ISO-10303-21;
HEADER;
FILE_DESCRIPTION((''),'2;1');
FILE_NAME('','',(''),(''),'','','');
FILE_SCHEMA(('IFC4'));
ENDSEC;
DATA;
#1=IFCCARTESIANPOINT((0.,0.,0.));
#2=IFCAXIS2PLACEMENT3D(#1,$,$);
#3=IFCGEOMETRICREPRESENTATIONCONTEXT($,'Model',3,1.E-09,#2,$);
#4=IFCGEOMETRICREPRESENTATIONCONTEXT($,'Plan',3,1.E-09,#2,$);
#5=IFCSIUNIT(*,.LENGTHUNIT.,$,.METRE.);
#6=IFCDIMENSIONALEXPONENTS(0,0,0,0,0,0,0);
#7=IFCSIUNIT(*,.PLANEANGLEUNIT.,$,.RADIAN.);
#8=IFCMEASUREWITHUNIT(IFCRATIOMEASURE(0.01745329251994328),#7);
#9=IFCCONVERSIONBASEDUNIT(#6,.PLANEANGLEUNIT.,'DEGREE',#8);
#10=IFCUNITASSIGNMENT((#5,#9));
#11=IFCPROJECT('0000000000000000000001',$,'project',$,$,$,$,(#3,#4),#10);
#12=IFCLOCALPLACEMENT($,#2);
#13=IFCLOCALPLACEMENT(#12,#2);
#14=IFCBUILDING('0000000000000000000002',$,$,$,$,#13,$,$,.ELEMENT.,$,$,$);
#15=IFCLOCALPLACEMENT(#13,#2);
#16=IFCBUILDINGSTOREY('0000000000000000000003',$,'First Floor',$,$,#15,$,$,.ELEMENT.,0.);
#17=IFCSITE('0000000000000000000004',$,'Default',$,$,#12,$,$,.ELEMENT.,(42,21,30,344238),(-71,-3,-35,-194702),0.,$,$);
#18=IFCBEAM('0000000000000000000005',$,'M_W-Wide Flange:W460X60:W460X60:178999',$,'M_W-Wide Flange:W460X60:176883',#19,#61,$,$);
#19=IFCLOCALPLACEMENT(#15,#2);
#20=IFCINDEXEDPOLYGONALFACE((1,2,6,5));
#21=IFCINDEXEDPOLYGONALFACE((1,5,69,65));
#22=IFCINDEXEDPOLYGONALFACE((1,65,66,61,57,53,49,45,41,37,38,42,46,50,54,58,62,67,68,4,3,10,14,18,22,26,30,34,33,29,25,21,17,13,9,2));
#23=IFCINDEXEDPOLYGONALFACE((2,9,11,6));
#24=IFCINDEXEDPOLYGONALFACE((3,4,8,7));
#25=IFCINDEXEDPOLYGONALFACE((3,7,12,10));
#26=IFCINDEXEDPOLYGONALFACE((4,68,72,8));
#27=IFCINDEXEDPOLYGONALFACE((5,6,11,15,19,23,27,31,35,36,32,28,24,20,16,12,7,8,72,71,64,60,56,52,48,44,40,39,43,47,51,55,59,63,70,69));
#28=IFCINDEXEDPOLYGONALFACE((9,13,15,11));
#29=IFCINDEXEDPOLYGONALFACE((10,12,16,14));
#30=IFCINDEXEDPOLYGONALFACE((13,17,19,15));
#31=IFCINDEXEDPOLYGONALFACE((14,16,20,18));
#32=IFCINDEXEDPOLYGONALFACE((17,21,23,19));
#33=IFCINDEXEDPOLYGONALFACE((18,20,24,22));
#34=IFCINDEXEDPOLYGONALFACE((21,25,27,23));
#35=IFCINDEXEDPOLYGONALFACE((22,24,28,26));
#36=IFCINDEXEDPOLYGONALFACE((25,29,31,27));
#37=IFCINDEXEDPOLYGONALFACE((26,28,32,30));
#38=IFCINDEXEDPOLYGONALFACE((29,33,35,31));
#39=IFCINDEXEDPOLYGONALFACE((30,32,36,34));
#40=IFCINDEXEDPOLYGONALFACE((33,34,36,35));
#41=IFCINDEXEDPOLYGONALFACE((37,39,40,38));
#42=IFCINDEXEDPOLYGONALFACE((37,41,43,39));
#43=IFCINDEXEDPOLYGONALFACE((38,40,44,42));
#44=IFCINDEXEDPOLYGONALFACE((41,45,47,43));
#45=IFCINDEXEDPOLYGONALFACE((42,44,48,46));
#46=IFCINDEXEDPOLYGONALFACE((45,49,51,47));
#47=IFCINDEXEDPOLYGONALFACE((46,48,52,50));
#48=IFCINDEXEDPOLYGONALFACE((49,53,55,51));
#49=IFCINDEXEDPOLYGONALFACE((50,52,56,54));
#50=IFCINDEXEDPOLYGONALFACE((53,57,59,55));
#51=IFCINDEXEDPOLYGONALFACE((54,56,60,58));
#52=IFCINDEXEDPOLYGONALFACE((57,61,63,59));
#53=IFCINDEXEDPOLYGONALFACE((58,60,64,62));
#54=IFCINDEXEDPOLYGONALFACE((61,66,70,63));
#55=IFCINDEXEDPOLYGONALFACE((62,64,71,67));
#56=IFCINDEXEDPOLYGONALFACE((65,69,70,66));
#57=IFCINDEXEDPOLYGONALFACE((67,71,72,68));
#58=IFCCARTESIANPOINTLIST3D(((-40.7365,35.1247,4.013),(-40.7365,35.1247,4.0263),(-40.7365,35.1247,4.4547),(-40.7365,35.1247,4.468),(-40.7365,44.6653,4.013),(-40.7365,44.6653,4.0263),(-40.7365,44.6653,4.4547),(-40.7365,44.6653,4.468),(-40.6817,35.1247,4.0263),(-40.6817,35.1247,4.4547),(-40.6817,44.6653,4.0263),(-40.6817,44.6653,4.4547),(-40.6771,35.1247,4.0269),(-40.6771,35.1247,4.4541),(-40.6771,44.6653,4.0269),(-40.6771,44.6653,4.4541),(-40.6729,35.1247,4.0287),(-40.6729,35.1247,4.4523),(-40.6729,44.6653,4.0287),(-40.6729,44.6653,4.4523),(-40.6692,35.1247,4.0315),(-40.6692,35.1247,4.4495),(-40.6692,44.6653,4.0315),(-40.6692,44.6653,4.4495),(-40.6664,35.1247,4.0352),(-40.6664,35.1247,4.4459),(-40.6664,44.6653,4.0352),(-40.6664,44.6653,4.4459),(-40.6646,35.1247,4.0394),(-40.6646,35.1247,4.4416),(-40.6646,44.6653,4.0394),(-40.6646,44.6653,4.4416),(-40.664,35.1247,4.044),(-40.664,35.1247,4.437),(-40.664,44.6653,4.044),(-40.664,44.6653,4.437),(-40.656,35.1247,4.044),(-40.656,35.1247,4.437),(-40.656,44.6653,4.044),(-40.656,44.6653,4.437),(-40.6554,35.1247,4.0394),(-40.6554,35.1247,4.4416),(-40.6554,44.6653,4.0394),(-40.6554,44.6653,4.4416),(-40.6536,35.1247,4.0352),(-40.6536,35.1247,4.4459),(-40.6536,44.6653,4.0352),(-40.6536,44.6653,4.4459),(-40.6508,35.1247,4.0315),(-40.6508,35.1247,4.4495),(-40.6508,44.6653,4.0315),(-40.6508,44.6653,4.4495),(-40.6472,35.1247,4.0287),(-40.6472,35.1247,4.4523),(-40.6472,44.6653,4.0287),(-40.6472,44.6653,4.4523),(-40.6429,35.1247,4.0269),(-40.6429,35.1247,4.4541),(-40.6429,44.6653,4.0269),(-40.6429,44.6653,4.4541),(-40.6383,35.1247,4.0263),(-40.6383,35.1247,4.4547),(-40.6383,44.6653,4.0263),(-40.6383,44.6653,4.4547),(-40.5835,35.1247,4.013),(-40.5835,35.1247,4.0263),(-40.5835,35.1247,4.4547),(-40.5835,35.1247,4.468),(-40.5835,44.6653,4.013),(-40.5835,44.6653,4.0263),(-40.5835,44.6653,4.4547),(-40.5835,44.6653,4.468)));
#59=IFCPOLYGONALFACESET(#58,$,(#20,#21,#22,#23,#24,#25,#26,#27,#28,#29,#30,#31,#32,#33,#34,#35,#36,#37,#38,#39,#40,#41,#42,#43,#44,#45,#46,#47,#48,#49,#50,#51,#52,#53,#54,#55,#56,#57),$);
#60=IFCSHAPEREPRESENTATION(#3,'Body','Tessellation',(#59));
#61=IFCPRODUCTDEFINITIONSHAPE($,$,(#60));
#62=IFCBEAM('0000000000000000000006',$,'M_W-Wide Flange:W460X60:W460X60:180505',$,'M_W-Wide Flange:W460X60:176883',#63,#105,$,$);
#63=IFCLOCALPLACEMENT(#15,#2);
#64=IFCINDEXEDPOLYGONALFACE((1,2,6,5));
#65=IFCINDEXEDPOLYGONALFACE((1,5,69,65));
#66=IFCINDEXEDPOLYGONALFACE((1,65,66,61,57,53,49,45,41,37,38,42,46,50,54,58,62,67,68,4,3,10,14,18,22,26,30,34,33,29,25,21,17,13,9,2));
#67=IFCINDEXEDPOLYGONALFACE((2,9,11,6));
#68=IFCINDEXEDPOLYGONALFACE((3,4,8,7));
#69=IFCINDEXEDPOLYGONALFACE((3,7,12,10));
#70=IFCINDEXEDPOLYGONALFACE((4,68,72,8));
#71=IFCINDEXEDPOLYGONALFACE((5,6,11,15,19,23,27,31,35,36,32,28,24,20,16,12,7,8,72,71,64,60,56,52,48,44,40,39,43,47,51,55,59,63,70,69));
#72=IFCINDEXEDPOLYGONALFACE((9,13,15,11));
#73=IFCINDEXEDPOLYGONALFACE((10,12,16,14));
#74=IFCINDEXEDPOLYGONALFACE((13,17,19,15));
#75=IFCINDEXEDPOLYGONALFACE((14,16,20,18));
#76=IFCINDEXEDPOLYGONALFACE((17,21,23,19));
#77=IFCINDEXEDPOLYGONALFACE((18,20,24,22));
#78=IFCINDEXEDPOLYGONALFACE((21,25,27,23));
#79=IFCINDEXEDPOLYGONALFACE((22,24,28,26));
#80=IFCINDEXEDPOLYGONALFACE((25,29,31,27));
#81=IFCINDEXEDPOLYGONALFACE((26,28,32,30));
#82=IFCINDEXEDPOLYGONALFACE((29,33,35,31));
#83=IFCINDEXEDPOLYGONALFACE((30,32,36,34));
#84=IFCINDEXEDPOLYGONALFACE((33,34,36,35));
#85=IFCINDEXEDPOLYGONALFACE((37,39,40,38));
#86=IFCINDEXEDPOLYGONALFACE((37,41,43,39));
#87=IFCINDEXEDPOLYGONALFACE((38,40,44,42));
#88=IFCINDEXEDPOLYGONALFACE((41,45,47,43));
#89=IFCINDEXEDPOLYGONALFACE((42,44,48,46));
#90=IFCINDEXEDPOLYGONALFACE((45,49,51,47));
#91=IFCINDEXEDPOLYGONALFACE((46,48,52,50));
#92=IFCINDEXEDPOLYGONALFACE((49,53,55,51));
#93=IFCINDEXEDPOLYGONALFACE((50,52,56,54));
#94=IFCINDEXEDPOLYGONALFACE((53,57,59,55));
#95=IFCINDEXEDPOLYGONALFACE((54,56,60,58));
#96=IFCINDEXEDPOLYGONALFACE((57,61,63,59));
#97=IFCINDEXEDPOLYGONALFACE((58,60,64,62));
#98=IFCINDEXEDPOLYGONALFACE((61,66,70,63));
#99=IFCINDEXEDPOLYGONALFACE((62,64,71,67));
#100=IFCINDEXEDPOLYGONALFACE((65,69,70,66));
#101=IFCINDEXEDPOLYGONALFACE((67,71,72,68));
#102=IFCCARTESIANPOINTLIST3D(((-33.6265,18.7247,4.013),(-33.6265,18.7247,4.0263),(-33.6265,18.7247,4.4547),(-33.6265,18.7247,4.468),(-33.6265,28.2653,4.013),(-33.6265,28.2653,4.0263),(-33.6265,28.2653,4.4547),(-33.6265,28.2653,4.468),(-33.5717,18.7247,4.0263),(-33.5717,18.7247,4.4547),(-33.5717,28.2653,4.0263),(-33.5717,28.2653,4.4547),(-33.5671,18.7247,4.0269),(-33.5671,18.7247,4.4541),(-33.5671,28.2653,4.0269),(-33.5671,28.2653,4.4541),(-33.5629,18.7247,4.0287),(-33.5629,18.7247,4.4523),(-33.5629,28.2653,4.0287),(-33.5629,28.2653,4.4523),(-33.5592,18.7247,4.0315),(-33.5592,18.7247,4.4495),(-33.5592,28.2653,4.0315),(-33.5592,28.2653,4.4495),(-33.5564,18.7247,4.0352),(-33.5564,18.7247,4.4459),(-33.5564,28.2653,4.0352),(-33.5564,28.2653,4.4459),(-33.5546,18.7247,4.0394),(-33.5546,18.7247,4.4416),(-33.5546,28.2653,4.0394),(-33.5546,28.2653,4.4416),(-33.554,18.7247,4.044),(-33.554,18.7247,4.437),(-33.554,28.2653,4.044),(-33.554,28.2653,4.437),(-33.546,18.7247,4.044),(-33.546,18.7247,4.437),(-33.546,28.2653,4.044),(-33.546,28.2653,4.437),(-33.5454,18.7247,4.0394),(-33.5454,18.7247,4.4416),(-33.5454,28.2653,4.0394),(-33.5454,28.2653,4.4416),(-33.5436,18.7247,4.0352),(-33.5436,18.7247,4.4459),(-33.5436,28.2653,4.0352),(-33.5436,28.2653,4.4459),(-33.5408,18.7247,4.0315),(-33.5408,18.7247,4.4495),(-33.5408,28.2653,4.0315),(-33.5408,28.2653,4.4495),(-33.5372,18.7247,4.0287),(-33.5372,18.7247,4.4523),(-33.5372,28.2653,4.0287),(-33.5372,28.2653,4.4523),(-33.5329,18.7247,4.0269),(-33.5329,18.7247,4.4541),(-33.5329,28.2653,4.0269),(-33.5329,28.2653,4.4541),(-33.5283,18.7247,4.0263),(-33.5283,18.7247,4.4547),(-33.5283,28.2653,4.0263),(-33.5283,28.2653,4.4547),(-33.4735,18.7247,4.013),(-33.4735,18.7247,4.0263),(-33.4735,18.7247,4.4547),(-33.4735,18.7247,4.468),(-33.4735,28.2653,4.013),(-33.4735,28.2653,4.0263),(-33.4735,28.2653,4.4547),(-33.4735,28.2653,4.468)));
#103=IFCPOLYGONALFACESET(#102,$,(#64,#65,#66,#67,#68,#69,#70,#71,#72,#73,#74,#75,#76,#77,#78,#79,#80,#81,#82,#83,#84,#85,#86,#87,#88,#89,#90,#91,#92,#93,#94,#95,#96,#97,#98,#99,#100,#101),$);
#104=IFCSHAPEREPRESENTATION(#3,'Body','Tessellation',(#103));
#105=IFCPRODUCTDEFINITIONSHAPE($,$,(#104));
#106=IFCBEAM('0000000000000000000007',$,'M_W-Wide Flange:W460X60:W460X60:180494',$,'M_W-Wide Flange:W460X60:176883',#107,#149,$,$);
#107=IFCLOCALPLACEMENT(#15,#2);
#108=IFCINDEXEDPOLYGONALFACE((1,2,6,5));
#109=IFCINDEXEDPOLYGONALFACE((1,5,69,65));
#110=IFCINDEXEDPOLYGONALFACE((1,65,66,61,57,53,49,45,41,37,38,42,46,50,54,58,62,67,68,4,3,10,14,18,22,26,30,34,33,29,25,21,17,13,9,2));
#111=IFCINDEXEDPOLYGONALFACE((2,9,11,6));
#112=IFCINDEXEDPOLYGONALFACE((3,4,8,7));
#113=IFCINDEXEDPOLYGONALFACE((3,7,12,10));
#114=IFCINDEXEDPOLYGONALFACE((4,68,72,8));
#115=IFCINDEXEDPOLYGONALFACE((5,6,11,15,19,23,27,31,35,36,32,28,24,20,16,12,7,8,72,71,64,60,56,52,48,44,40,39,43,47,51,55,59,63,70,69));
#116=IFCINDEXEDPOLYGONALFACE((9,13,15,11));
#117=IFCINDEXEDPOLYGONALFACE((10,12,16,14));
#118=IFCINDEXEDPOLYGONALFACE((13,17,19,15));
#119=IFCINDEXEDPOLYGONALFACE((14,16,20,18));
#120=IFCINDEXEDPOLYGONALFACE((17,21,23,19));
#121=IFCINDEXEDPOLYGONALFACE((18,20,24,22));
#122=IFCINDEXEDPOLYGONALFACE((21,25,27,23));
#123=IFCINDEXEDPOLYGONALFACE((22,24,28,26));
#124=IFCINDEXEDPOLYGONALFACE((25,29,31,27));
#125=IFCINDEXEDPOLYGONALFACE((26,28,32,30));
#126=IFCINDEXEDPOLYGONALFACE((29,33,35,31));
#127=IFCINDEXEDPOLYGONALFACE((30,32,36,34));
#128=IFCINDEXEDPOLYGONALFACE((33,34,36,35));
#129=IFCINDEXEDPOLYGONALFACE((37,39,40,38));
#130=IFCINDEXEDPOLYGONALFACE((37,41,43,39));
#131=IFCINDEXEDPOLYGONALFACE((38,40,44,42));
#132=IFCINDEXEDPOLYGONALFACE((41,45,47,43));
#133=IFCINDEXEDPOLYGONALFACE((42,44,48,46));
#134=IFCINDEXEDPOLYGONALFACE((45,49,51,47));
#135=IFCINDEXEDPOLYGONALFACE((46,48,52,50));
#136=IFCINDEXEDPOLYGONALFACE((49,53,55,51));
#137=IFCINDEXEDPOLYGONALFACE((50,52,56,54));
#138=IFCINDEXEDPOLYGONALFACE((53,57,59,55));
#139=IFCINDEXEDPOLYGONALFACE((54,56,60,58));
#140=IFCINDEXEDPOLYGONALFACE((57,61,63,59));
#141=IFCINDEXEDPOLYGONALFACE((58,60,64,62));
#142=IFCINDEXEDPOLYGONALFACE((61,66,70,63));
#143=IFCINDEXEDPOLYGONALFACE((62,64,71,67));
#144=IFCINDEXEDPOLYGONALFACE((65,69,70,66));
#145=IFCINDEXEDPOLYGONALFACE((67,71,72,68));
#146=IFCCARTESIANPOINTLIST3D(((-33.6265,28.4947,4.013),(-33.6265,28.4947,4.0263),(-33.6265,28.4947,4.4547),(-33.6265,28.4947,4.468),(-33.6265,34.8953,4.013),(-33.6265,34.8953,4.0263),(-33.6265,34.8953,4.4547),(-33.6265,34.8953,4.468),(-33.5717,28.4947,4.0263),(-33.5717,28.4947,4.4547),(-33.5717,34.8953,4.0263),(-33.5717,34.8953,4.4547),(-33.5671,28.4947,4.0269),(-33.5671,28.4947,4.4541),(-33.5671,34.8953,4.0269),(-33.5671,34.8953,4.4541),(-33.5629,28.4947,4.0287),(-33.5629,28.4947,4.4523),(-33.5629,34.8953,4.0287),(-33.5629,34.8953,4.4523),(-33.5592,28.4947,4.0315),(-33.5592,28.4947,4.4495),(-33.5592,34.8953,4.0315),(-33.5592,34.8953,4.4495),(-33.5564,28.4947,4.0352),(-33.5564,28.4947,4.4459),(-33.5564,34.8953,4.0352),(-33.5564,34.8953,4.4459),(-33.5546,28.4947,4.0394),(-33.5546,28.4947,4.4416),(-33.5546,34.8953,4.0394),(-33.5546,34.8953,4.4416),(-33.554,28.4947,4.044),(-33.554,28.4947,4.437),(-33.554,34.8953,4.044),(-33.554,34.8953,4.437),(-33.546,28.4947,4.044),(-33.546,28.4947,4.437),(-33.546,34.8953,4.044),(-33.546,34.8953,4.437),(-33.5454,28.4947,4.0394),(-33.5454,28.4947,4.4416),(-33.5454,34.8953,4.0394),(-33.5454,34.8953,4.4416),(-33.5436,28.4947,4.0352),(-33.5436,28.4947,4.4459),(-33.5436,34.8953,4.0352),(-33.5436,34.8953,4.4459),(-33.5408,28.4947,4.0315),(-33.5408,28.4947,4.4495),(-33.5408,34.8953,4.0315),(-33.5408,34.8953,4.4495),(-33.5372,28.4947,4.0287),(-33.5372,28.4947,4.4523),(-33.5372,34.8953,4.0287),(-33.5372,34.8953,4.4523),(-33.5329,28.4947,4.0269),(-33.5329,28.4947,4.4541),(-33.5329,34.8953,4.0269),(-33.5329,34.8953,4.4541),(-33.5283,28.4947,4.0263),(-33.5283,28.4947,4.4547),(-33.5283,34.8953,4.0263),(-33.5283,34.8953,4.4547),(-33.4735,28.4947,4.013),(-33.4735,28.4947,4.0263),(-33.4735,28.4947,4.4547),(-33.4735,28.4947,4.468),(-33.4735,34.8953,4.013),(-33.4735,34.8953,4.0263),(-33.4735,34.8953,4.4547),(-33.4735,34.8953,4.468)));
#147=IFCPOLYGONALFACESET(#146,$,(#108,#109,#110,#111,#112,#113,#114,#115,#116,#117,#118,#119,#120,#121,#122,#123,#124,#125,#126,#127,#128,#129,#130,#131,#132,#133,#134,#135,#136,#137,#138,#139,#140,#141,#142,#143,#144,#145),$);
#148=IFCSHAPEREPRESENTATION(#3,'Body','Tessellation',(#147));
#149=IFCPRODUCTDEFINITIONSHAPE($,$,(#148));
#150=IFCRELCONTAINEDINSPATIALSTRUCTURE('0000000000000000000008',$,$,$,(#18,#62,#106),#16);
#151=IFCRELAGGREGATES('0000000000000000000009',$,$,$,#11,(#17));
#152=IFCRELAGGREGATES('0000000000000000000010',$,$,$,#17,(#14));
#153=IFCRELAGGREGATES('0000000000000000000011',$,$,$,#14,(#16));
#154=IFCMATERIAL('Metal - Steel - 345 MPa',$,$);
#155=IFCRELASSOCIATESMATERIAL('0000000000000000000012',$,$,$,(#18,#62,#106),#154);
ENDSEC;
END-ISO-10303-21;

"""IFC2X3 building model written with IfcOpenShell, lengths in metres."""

from ifc_helpers import new_model, entity, si_unit, converted_unit, frame, frame_2d, origin, place, context, project, spatial, polyline, circle_curve, parameter, trimmed, segment, composite_curve, outline, extrude, material, element, save


model = new_model("IFC2X3")

# Units and contexts
model_context = context("Model", 3, precision=1e-09, world=origin())
plan_context = context("Plan", 3, precision=1e-09, world=origin())
ifc_project = project(units=[si_unit("LENGTHUNIT", "METRE"), converted_unit("PLANEANGLEUNIT", "DEGREE", entity("IfcRatioMeasure", 0.01745329251994328), si_unit("PLANEANGLEUNIT", "RADIAN"), dimensions=[0, 0, 0, 0, 0, 0, 0])], contexts=[model_context, plan_context])

# Site, building, storey
site_placement = place(None, origin())
site = spatial("IfcSite", under=ifc_project, at=site_placement, Name="Default", CompositionType="ELEMENT", RefLatitude=(42, 21, 30, 344238), RefLongitude=(-71, -3, -35, -194702), RefElevation=0.0)
building_placement = place(site_placement, origin())
building = spatial("IfcBuilding", under=site, at=building_placement, CompositionType="ELEMENT")
storey_placement = place(building_placement, origin())
storey = spatial("IfcBuildingStorey", under=building, at=storey_placement, Name="First Floor", CompositionType="ELEMENT", Elevation=0.0)

# Beams
ifc_material = material(Name="Metal - Steel - 345 MPa")
beam_1_placement = place(storey_placement, frame((-40.66, 44.7814, 4.468), z_axis=(0.0, 0.0, 1.0), x_axis=(-1.0, 0.0, 0.0)))
element("IfcBeam", 1, at=beam_1_placement, inside=storey, material=ifc_material, Name="M_W-Wide Flange:W460X60:W460X60:178999", ObjectType="M_W-Wide Flange:W460X60:176883", context=model_context, shape_type="SweptSolid", body=[
    extrude(outline(composite_curve([segment(polyline([(0.2142, -0.0765), (0.2275, -0.0765)]), True, "CONTINUOUS"), segment(polyline([(0.2275, -0.0765), (0.2275, 0.0765)]), True, "CONTINUOUS"), segment(polyline([(0.2275, 0.0765), (0.2142, 0.0765)]), True, "CONTINUOUS"), segment(polyline([(0.2142, 0.0765), (0.2142, 0.0217)]), True, "CONTINUOUS"), segment(trimmed(circle_curve(frame_2d((0.1965, 0.0217), x_axis=(1.0, 0.0)), 0.0177), [parameter(270.0)], [parameter(360.0)], True, "PARAMETER"), False, "CONTINUOUS"), segment(polyline([(0.1965, 0.004), (-0.1965, 0.004)]), True, "CONTINUOUS"), segment(trimmed(circle_curve(frame_2d((-0.1965, 0.0217), x_axis=(0.0, -1.0)), 0.0177), [parameter(270.0)], [parameter(360.0)], True, "PARAMETER"), False, "CONTINUOUS"), segment(polyline([(-0.2142, 0.0217), (-0.2142, 0.0765)]), True, "CONTINUOUS"), segment(polyline([(-0.2142, 0.0765), (-0.2275, 0.0765)]), True, "CONTINUOUS"), segment(polyline([(-0.2275, 0.0765), (-0.2275, -0.0765)]), True, "CONTINUOUS"), segment(polyline([(-0.2275, -0.0765), (-0.2142, -0.0765)]), True, "CONTINUOUS"), segment(polyline([(-0.2142, -0.0765), (-0.2142, -0.0217)]), True, "CONTINUOUS"), segment(trimmed(circle_curve(frame_2d((-0.1965, -0.0217), x_axis=(-1.0, 0.0)), 0.0177), [parameter(270.0)], [parameter(360.0)], True, "PARAMETER"), False, "CONTINUOUS"), segment(polyline([(-0.1965, -0.004), (0.1965, -0.004)]), True, "CONTINUOUS"), segment(trimmed(circle_curve(frame_2d((0.1965, -0.0217), x_axis=(0.0, 1.0)), 0.0177), [parameter(270.0)], [parameter(0.0)], True, "PARAMETER"), False, "CONTINUOUS"), segment(polyline([(0.2142, -0.0217), (0.2142, -0.0765)]), True, "CONTINUOUS")], self_intersect=False)), frame((0.0, 9.6567, -0.2275), z_axis=(0.0, -1.0, 0.0), x_axis=(0.0, 0.0, -1.0)), (0.0, 0.0, 1.0), 9.5406),
])
beam_2_placement = place(storey_placement, frame((-33.55, 28.3814, 4.468), z_axis=(0.0, 0.0, 1.0), x_axis=(-1.0, 0.0, 0.0)))
element("IfcBeam", 2, at=beam_2_placement, inside=storey, material=ifc_material, Name="M_W-Wide Flange:W460X60:W460X60:180505", ObjectType="M_W-Wide Flange:W460X60:176883", context=model_context, shape_type="SweptSolid", body=[
    extrude(outline(composite_curve([segment(polyline([(0.2142, -0.0765), (0.2275, -0.0765)]), True, "CONTINUOUS"), segment(polyline([(0.2275, -0.0765), (0.2275, 0.0765)]), True, "CONTINUOUS"), segment(polyline([(0.2275, 0.0765), (0.2142, 0.0765)]), True, "CONTINUOUS"), segment(polyline([(0.2142, 0.0765), (0.2142, 0.0217)]), True, "CONTINUOUS"), segment(trimmed(circle_curve(frame_2d((0.1965, 0.0217), x_axis=(1.0, 0.0)), 0.0177), [parameter(270.0)], [parameter(360.0)], True, "PARAMETER"), False, "CONTINUOUS"), segment(polyline([(0.1965, 0.004), (-0.1965, 0.004)]), True, "CONTINUOUS"), segment(trimmed(circle_curve(frame_2d((-0.1965, 0.0217), x_axis=(0.0, -1.0)), 0.0177), [parameter(270.0)], [parameter(360.0)], True, "PARAMETER"), False, "CONTINUOUS"), segment(polyline([(-0.2142, 0.0217), (-0.2142, 0.0765)]), True, "CONTINUOUS"), segment(polyline([(-0.2142, 0.0765), (-0.2275, 0.0765)]), True, "CONTINUOUS"), segment(polyline([(-0.2275, 0.0765), (-0.2275, -0.0765)]), True, "CONTINUOUS"), segment(polyline([(-0.2275, -0.0765), (-0.2142, -0.0765)]), True, "CONTINUOUS"), segment(polyline([(-0.2142, -0.0765), (-0.2142, -0.0217)]), True, "CONTINUOUS"), segment(trimmed(circle_curve(frame_2d((-0.1965, -0.0217), x_axis=(-1.0, 0.0)), 0.0177), [parameter(270.0)], [parameter(360.0)], True, "PARAMETER"), False, "CONTINUOUS"), segment(polyline([(-0.1965, -0.004), (0.1965, -0.004)]), True, "CONTINUOUS"), segment(trimmed(circle_curve(frame_2d((0.1965, -0.0217), x_axis=(0.0, 1.0)), 0.0177), [parameter(270.0)], [parameter(0.0)], True, "PARAMETER"), False, "CONTINUOUS"), segment(polyline([(0.2142, -0.0217), (0.2142, -0.0765)]), True, "CONTINUOUS")], self_intersect=False)), frame((0.0, 9.6567, -0.2275), z_axis=(0.0, -1.0, 0.0), x_axis=(0.0, 0.0, -1.0)), (0.0, 0.0, 1.0), 9.5406),
])
beam_3_placement = place(storey_placement, frame((-33.55, 35.0121, 4.468), z_axis=(0.0, 0.0, 1.0), x_axis=(-1.0, 0.0, 0.0)))
element("IfcBeam", 3, at=beam_3_placement, inside=storey, material=ifc_material, Name="M_W-Wide Flange:W460X60:W460X60:180494", ObjectType="M_W-Wide Flange:W460X60:176883", context=model_context, shape_type="SweptSolid", body=[
    extrude(outline(composite_curve([segment(polyline([(0.2142, -0.0765), (0.2275, -0.0765)]), True, "CONTINUOUS"), segment(polyline([(0.2275, -0.0765), (0.2275, 0.0765)]), True, "CONTINUOUS"), segment(polyline([(0.2275, 0.0765), (0.2142, 0.0765)]), True, "CONTINUOUS"), segment(polyline([(0.2142, 0.0765), (0.2142, 0.0217)]), True, "CONTINUOUS"), segment(trimmed(circle_curve(frame_2d((0.1965, 0.0217), x_axis=(1.0, 0.0)), 0.0177), [parameter(270.0)], [parameter(360.0)], True, "PARAMETER"), False, "CONTINUOUS"), segment(polyline([(0.1965, 0.004), (-0.1965, 0.004)]), True, "CONTINUOUS"), segment(trimmed(circle_curve(frame_2d((-0.1965, 0.0217), x_axis=(0.0, -1.0)), 0.0177), [parameter(270.0)], [parameter(360.0)], True, "PARAMETER"), False, "CONTINUOUS"), segment(polyline([(-0.2142, 0.0217), (-0.2142, 0.0765)]), True, "CONTINUOUS"), segment(polyline([(-0.2142, 0.0765), (-0.2275, 0.0765)]), True, "CONTINUOUS"), segment(polyline([(-0.2275, 0.0765), (-0.2275, -0.0765)]), True, "CONTINUOUS"), segment(polyline([(-0.2275, -0.0765), (-0.2142, -0.0765)]), True, "CONTINUOUS"), segment(polyline([(-0.2142, -0.0765), (-0.2142, -0.0217)]), True, "CONTINUOUS"), segment(trimmed(circle_curve(frame_2d((-0.1965, -0.0217), x_axis=(-1.0, 0.0)), 0.0177), [parameter(270.0)], [parameter(360.0)], True, "PARAMETER"), False, "CONTINUOUS"), segment(polyline([(-0.1965, -0.004), (0.1965, -0.004)]), True, "CONTINUOUS"), segment(trimmed(circle_curve(frame_2d((0.1965, -0.0217), x_axis=(0.0, 1.0)), 0.0177), [parameter(270.0)], [parameter(0.0)], True, "PARAMETER"), False, "CONTINUOUS"), segment(polyline([(0.2142, -0.0217), (0.2142, -0.0765)]), True, "CONTINUOUS")], self_intersect=False)), frame((0.0, 6.5174, -0.2275), z_axis=(0.0, -1.0, 0.0), x_axis=(0.0, 0.0, -1.0)), (0.0, 0.0, 1.0), 6.4006),
])

save(model, "model.ifc")
